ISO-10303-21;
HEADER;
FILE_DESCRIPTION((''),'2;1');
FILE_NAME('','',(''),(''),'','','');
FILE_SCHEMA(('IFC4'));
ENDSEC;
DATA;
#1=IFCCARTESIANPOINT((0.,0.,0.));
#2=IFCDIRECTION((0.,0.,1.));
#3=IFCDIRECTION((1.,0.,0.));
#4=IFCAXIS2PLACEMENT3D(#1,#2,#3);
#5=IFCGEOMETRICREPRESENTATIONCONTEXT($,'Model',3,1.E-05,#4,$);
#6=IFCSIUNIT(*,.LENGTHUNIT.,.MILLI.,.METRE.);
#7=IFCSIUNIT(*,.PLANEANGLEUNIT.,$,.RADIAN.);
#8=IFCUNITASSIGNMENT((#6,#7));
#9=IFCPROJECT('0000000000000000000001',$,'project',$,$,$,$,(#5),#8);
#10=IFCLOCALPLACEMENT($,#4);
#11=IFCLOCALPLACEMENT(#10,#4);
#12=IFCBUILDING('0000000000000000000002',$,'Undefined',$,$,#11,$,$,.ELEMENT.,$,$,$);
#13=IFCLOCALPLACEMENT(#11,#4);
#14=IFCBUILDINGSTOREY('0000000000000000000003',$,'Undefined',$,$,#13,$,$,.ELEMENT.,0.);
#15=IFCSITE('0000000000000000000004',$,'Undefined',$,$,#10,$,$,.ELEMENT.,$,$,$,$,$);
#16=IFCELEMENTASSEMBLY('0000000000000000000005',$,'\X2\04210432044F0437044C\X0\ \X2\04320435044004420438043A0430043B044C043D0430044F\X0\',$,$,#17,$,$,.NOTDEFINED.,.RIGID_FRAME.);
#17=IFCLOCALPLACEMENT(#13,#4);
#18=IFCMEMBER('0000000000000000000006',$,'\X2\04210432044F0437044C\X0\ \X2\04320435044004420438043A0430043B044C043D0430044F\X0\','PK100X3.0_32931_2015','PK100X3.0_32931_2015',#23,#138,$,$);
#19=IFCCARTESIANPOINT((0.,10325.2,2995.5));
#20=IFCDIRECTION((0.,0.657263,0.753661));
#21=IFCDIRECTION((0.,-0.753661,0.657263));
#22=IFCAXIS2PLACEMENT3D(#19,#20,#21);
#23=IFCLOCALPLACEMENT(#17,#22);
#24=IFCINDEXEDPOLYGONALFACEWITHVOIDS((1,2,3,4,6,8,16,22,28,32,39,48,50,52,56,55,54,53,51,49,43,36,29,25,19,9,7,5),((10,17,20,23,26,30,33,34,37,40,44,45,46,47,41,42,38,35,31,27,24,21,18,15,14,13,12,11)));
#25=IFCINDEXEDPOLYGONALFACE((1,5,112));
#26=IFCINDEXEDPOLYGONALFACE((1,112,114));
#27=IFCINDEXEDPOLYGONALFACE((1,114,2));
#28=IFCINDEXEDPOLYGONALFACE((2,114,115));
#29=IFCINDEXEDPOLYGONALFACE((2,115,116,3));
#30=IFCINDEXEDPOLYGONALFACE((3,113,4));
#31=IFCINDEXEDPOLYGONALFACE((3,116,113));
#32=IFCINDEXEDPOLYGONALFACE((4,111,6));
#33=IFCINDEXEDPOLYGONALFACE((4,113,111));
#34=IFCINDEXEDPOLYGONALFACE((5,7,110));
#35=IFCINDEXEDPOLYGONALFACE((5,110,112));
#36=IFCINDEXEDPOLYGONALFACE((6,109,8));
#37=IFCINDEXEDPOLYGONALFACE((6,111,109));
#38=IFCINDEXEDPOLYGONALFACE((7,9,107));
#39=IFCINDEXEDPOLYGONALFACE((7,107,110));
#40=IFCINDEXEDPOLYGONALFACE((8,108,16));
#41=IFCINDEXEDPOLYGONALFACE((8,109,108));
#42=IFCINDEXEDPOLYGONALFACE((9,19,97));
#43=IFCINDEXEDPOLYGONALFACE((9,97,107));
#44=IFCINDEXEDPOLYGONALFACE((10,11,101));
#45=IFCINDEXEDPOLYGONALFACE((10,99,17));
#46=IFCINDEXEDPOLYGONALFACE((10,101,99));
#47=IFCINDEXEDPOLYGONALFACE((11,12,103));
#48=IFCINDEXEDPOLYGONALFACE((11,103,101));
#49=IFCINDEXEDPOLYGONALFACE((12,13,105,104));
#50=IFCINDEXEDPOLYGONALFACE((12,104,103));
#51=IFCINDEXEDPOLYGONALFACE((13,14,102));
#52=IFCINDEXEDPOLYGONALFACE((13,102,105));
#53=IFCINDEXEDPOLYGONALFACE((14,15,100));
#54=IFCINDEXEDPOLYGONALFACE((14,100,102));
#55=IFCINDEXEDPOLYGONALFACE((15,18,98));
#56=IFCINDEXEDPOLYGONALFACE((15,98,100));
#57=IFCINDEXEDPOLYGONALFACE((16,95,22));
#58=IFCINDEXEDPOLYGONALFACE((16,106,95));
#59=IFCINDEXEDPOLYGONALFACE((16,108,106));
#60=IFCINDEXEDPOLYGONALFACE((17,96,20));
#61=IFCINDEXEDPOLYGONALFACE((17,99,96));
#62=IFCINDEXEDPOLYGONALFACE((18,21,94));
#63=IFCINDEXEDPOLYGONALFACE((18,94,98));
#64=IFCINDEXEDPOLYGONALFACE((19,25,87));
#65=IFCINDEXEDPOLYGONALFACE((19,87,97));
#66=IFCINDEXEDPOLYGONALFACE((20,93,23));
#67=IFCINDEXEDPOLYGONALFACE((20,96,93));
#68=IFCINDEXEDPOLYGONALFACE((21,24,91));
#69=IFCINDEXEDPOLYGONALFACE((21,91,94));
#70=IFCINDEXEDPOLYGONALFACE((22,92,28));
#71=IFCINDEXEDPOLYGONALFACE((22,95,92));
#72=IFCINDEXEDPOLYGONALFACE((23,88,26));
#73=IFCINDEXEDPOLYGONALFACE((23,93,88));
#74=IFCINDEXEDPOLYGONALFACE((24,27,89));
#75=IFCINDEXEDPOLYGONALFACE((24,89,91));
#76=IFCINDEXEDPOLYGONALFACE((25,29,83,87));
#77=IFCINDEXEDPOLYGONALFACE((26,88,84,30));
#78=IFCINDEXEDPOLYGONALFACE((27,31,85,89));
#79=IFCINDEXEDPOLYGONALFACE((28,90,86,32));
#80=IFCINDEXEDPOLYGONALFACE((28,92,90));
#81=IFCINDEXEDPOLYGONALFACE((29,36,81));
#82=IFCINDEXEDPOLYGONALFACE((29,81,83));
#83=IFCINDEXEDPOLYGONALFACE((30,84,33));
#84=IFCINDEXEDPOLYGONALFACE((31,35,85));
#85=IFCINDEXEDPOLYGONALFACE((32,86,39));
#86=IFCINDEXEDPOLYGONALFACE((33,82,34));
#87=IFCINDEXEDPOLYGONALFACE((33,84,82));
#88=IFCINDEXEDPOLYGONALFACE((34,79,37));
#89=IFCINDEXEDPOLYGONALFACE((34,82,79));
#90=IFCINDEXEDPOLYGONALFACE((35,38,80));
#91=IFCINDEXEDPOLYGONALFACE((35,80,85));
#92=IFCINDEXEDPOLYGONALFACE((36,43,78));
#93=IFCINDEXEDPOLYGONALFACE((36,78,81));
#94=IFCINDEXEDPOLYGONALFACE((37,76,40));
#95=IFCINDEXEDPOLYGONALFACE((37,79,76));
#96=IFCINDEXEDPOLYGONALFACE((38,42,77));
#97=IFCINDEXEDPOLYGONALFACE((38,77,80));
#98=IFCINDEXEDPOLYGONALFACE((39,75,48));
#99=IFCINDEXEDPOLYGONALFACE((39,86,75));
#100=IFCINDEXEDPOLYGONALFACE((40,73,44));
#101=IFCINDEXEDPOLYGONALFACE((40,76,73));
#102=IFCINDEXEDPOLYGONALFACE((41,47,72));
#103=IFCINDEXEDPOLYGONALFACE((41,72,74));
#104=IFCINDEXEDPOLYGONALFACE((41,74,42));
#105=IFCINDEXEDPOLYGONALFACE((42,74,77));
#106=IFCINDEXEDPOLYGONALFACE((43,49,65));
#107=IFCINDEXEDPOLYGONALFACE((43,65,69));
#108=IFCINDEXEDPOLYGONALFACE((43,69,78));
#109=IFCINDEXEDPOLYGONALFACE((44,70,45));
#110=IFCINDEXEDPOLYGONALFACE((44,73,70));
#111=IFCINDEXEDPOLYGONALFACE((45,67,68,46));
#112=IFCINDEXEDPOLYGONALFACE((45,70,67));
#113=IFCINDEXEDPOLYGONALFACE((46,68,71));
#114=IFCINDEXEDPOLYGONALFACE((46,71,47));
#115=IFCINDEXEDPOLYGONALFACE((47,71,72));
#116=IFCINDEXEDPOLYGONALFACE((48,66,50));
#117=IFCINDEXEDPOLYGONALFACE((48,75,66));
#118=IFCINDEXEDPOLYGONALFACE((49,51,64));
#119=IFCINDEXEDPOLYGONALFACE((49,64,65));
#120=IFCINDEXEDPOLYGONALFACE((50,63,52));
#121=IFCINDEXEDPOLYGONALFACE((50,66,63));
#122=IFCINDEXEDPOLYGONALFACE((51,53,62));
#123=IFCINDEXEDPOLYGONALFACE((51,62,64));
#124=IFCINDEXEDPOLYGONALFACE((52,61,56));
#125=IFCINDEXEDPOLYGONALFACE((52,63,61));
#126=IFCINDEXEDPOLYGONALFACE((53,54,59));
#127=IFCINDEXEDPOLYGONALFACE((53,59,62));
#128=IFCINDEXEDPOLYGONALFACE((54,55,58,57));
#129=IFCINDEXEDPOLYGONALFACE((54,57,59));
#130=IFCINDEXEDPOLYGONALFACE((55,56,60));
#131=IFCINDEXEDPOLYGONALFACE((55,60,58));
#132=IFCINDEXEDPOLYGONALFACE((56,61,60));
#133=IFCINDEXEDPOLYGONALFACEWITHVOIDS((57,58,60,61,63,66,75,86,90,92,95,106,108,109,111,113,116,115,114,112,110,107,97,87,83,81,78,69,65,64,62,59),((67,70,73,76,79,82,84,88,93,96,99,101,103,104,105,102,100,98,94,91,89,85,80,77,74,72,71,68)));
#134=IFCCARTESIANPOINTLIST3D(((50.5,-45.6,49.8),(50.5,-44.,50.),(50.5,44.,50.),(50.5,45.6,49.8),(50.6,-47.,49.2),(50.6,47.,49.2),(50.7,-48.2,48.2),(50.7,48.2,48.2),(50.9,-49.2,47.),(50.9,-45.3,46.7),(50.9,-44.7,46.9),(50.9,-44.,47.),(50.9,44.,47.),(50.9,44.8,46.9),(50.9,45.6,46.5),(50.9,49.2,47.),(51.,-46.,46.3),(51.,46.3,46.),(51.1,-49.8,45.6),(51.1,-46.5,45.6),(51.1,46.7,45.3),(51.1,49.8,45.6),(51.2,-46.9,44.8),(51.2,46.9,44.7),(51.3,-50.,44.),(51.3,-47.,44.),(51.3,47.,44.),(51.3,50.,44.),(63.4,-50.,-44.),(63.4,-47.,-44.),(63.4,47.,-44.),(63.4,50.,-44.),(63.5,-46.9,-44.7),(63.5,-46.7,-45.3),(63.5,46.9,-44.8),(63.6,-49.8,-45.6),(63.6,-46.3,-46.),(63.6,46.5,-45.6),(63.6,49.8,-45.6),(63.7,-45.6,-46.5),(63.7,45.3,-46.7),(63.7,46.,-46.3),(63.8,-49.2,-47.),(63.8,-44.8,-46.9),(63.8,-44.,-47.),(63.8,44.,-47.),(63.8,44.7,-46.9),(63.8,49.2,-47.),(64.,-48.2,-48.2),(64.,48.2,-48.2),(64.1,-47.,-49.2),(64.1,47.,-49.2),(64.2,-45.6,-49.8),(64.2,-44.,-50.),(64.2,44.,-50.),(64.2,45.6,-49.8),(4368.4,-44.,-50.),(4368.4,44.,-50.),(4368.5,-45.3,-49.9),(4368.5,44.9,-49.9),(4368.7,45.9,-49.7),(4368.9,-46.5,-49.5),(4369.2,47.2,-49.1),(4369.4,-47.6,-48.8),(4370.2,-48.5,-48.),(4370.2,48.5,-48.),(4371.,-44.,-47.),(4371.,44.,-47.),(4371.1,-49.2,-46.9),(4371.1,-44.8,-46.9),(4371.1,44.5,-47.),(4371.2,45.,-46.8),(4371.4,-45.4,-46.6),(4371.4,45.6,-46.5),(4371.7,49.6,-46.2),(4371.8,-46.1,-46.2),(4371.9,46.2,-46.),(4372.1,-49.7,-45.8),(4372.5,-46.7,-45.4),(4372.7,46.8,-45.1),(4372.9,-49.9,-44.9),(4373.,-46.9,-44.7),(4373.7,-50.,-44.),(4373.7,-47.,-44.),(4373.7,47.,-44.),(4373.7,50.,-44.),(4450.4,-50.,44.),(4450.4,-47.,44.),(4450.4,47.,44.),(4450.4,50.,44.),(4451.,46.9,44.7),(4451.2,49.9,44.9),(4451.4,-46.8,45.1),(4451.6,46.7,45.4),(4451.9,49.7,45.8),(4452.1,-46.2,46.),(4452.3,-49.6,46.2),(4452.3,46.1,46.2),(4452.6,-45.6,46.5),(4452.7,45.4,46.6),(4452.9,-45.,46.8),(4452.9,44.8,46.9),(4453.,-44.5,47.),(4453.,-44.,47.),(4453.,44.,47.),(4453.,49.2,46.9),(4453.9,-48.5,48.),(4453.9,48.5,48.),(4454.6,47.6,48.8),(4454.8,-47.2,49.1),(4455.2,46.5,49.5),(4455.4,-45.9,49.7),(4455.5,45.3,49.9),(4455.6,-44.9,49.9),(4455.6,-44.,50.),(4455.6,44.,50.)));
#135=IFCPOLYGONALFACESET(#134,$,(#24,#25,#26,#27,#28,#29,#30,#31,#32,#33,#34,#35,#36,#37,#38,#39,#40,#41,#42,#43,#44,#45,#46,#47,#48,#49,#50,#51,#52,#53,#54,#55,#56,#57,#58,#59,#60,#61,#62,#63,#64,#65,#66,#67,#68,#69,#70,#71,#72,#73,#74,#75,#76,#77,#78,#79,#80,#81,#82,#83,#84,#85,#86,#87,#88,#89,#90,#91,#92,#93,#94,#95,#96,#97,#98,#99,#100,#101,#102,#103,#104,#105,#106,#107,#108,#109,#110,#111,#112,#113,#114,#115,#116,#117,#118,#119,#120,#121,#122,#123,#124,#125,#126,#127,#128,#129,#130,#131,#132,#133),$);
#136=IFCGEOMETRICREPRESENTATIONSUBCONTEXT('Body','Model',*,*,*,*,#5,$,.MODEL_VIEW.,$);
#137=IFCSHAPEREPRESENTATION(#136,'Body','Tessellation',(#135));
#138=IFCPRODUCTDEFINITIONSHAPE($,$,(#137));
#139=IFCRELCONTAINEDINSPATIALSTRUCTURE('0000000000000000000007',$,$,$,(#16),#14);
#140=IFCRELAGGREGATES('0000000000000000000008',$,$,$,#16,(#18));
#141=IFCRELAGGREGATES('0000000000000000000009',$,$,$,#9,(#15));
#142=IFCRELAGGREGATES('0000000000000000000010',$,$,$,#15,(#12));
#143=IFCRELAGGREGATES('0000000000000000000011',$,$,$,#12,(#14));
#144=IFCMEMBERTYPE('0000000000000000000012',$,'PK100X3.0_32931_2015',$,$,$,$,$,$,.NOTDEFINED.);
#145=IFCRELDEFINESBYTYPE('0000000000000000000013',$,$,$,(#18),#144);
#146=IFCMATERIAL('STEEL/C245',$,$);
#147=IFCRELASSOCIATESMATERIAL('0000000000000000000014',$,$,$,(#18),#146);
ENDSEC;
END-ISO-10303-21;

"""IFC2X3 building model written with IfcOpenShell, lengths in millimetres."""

from ifc_helpers import new_model, si_unit, frame, origin_with_axes, origin_2d_with_axis, place, context, subcontext, project, spatial, hollow_rectangle, extrude, clip, halfspace, material, type_object, element, aggregate, save


model = new_model("IFC2X3")

# Units and contexts
model_context = context("Model", 3, precision=1e-05, world=origin_with_axes())
body_context = subcontext(model_context, "Body", "Model", "MODEL_VIEW")
ifc_project = project(units=[si_unit("LENGTHUNIT", "METRE", prefix="MILLI"), si_unit("PLANEANGLEUNIT", "RADIAN")], contexts=[model_context])

# Site, building, storey
site_placement = place(None, origin_with_axes())
site = spatial("IfcSite", under=ifc_project, at=site_placement, Name="Undefined", CompositionType="ELEMENT")
building_placement = place(site_placement, origin_with_axes())
building = spatial("IfcBuilding", under=site, at=building_placement, Name="Undefined", CompositionType="ELEMENT")
storey_placement = place(building_placement, origin_with_axes())
storey = spatial("IfcBuildingStorey", under=building, at=storey_placement, Name="Undefined", CompositionType="ELEMENT", Elevation=0.0)

# Shared definitions
ifc_material = material(Name="STEEL/C245")

# Element assembly, member
assembly_1_placement = place(storey_placement, origin_with_axes())
assembly_1 = element("IfcElementAssembly", 1, at=assembly_1_placement, inside=storey, Name="Связь вертикальная", AssemblyPlace="NOTDEFINED", PredefinedType="RIGID_FRAME")
member_type_1 = type_object("IfcMemberType", Name="PK100X3.0_32931_2015", PredefinedType="NOTDEFINED")
member_1_placement = place(assembly_1_placement, frame((0.0, 10325.2, 2995.5), z_axis=(0.0, 0.657263, 0.753661), x_axis=(0.0, -0.753661, 0.657263)))
member_1 = element("IfcMember", 2, at=member_1_placement, type_object=member_type_1, material=ifc_material, Name="Связь вертикальная", Description="PK100X3.0_32931_2015", ObjectType="PK100X3.0_32931_2015", context=body_context, shape_type="Clipping", body=[
    clip(clip(extrude(hollow_rectangle(XDim=100.0, YDim=100.0, WallThickness=3.0, InnerFilletRadius=3.0, OuterFilletRadius=6.0, at=origin_2d_with_axis()), frame((4507.0, 0.0, 0.0), z_axis=(-1.0, 0.0, 0.0), x_axis=(0.0, -1.0, 0.0)), (0.0, 0.0, 1.0), 4544.7), halfspace(frame((4327.7, 0.0, -96.7), z_axis=(-0.753661, 0.0, 0.657263), x_axis=(-0.657263, 0.0, -0.753661)), True)), halfspace(frame((84.2, 0.0, -195.6), z_axis=(-0.990707, 0.0, -0.136011), x_axis=(0.0, 1.0, 0.0)), False)),
])
aggregate(assembly_1, [member_1])

save(model, "model.ifc")
